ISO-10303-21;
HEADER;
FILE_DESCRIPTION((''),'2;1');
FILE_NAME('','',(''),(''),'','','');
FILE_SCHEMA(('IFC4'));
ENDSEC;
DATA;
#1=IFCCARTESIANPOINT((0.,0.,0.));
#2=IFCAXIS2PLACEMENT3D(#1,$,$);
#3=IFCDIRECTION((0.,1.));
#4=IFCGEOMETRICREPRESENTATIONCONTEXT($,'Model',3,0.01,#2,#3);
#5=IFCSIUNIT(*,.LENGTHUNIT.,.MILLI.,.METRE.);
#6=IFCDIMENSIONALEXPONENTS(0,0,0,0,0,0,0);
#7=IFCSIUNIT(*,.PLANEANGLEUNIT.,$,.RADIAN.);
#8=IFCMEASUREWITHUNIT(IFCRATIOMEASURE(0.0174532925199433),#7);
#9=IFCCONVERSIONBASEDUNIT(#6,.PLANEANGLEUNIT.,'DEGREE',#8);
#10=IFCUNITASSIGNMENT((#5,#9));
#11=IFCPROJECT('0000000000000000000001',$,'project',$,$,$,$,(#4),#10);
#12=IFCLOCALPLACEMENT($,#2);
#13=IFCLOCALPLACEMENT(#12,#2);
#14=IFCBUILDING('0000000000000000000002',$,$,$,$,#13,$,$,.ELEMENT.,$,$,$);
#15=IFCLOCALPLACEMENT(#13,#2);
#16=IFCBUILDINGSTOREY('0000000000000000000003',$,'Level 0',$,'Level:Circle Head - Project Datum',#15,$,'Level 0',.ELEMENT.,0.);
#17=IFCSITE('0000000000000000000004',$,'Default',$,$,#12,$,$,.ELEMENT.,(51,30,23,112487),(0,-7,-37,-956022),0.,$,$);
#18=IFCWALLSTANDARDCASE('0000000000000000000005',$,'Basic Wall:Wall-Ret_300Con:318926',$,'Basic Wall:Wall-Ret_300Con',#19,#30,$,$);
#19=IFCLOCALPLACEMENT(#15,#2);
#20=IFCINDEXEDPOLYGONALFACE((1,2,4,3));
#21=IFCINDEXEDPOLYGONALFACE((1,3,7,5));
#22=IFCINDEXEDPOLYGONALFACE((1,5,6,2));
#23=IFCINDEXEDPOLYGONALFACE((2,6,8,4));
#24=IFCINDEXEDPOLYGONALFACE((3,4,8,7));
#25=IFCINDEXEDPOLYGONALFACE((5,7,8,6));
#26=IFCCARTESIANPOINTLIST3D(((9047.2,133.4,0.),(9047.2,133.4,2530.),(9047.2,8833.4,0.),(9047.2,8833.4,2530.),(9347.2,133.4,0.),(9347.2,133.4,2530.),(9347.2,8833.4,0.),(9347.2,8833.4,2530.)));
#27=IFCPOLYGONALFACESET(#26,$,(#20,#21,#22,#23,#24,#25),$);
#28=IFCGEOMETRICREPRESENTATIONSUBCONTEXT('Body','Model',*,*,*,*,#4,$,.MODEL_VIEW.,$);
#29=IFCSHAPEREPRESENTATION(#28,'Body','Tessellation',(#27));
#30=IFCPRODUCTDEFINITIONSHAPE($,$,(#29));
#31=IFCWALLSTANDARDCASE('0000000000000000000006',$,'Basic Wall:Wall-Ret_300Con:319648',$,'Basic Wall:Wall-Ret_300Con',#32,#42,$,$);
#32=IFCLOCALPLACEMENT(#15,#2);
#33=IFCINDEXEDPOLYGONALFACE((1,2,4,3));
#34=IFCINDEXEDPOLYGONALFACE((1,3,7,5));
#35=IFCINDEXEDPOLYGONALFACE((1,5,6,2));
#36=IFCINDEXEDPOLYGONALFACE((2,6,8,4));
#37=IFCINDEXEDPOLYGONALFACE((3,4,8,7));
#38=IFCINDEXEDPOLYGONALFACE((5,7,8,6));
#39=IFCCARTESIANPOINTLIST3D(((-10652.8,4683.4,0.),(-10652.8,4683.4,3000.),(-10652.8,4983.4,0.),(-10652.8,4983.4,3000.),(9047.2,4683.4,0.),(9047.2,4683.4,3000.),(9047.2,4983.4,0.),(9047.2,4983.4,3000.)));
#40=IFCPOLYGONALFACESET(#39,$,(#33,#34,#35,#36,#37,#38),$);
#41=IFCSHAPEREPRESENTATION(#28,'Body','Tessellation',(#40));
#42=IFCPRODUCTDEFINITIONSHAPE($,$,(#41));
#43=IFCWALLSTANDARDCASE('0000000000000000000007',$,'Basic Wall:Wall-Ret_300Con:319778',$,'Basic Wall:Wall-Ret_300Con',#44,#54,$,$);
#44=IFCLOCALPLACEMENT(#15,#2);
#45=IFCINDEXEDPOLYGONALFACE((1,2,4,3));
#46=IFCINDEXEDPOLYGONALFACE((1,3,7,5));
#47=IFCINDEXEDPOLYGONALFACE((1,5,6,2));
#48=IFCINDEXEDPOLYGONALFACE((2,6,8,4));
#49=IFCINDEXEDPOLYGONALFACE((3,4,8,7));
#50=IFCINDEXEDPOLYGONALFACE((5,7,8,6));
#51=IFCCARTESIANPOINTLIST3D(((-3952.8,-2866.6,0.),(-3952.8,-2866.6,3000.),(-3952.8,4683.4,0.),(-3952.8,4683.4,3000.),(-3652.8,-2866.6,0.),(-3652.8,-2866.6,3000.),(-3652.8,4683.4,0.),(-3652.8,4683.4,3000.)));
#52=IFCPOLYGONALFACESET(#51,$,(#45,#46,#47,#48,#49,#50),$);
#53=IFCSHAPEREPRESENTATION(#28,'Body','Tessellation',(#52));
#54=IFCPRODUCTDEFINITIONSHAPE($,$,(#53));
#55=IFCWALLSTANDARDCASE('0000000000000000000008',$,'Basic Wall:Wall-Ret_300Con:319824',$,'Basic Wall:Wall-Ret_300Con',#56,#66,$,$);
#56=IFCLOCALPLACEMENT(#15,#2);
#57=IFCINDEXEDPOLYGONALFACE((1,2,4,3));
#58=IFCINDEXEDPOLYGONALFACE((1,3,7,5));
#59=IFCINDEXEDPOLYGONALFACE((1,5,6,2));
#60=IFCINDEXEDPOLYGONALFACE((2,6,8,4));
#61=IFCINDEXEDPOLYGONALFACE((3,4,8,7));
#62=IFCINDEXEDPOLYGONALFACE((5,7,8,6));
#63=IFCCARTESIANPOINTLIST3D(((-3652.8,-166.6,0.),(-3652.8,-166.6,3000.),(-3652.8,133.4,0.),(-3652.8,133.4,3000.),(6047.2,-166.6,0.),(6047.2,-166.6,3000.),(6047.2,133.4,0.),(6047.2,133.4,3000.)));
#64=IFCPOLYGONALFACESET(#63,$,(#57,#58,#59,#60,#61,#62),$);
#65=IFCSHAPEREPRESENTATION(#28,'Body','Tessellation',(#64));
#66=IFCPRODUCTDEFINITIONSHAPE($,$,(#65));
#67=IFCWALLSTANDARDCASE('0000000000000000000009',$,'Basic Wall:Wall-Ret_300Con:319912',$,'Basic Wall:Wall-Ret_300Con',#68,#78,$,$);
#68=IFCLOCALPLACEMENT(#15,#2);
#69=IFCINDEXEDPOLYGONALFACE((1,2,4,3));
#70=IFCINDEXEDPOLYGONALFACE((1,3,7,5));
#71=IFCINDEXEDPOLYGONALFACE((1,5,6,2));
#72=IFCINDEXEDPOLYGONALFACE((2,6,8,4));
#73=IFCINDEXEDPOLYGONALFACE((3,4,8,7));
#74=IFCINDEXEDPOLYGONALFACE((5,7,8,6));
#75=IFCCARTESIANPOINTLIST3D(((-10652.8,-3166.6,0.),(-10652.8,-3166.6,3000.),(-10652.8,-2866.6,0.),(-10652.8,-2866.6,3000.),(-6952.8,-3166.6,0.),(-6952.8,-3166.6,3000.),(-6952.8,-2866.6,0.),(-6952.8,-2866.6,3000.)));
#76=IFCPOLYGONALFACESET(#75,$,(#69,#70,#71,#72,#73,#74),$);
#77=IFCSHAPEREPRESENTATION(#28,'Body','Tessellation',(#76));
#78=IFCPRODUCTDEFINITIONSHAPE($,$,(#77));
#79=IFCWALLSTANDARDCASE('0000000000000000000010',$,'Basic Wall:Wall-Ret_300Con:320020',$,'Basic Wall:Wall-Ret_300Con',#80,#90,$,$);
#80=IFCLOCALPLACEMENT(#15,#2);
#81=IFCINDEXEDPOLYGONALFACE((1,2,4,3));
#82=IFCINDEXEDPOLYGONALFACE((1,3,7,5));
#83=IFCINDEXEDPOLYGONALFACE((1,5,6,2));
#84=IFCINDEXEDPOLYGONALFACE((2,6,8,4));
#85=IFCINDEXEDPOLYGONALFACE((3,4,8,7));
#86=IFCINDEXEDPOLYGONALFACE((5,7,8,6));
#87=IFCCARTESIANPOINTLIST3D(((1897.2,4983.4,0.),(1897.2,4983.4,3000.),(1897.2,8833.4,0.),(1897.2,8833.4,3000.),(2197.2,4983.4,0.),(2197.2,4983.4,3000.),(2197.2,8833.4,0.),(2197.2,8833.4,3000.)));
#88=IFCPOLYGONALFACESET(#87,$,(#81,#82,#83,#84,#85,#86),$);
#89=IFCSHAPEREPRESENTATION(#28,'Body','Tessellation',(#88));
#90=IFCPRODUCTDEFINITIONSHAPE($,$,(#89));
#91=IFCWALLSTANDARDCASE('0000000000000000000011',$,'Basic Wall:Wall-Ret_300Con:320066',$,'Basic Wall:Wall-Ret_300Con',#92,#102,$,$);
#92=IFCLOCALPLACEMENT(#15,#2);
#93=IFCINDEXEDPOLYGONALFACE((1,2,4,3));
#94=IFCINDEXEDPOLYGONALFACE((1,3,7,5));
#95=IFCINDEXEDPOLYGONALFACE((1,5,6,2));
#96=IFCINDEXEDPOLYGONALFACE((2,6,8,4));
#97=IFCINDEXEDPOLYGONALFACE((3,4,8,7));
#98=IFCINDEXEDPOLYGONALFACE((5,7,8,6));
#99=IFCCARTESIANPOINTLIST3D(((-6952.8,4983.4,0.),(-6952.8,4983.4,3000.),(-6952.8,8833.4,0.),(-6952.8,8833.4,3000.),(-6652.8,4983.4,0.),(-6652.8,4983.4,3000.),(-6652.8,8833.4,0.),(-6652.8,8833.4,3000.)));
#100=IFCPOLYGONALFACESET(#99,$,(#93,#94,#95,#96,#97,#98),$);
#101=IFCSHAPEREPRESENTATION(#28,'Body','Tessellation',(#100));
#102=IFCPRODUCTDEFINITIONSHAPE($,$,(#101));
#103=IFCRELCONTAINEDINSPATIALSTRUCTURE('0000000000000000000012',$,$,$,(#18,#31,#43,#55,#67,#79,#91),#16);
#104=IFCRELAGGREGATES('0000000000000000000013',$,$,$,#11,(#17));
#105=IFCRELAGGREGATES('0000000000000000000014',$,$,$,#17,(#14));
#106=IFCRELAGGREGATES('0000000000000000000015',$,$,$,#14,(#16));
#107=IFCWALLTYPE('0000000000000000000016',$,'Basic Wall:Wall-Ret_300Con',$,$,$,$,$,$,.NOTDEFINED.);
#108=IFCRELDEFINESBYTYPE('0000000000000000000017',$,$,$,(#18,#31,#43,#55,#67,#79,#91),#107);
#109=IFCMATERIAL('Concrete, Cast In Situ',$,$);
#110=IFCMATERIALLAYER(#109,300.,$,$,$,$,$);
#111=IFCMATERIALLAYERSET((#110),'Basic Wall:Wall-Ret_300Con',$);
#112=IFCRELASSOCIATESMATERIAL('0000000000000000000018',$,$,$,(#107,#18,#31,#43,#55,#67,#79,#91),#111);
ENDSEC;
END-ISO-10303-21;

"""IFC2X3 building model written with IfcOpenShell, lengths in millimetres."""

from ifc_helpers import new_model, entity, si_unit, converted_unit, direction, frame, frame_2d, origin, place, context, subcontext, project, spatial, polyline, rectangle, extrude, clip, bounded_halfspace, material, layer, layer_set, layer_usage, type_object, element, save


model = new_model("IFC2X3")

# Units and contexts
model_context = context("Model", 3, precision=0.01, world=origin(), true_north=direction((0.0, 1.0)))
body_context = subcontext(model_context, "Body", "Model", "MODEL_VIEW")
ifc_project = project(units=[si_unit("LENGTHUNIT", "METRE", prefix="MILLI"), converted_unit("PLANEANGLEUNIT", "DEGREE", entity("IfcRatioMeasure", 0.0174532925199433), si_unit("PLANEANGLEUNIT", "RADIAN"), dimensions=[0, 0, 0, 0, 0, 0, 0])], contexts=[model_context])

# Site, building, storey
site_placement = place(None, origin())
site = spatial("IfcSite", under=ifc_project, at=site_placement, Name="Default", CompositionType="ELEMENT", RefLatitude=(51, 30, 23, 112487), RefLongitude=(0, -7, -37, -956022), RefElevation=0.0)
building_placement = place(site_placement, origin())
building = spatial("IfcBuilding", under=site, at=building_placement, CompositionType="ELEMENT")
storey_placement = place(building_placement, origin())
storey = spatial("IfcBuildingStorey", under=building, at=storey_placement, Name="Level 0", ObjectType="Level:Circle Head - Project Datum", LongName="Level 0", CompositionType="ELEMENT", Elevation=0.0)

# Walls
ifc_material_1 = material(Name="Concrete, Cast In Situ")
ifc_layer_1 = layer(ifc_material_1, 300.0)
ifc_layer_set_1 = layer_set([ifc_layer_1], Name="Basic Wall:Wall-Ret_300Con")
wall_type = type_object("IfcWallType", Name="Basic Wall:Wall-Ret_300Con", PredefinedType="NOTDEFINED", material=ifc_layer_set_1)
ifc_layer_usage_1 = layer_usage(ifc_layer_set_1, "AXIS2", "NEGATIVE", 150.0)
wall_1_placement = place(storey_placement, frame((9197.2, 8833.4, 0.0), z_axis=(0.0, 0.0, 1.0), x_axis=(0.0, -1.0, 0.0)))
element("IfcWallStandardCase", 1, at=wall_1_placement, inside=storey, type_object=wall_type, material=ifc_layer_usage_1, Name="Basic Wall:Wall-Ret_300Con:318926", ObjectType="Basic Wall:Wall-Ret_300Con", context=body_context, shape_type="Clipping", body=[
    clip(extrude(rectangle(XDim=8700.0, YDim=300.0, at=frame_2d((4350.0, 0.0), x_axis=(-1.0, 0.0))), origin(), (0.0, 0.0, 1.0), 2530.0), bounded_halfspace(frame((0.0, -150.0, 2530.0), z_axis=(0.0, 0.0, -1.0), x_axis=(0.0, 1.0, 0.0)), True, frame((0.0, -150.0, 2530.0)), polyline([(0.0, 0.0), (8700.0, 0.0), (8700.0, 300.0), (0.0, 300.0), (0.0, 0.0)]))),
])
ifc_layer_usage_2 = layer_usage(ifc_layer_set_1, "AXIS2", "NEGATIVE", 150.0)
wall_2_placement = place(storey_placement, frame((-10652.8, 4833.4, 0.0)))
element("IfcWallStandardCase", 2, at=wall_2_placement, inside=storey, type_object=wall_type, material=ifc_layer_usage_2, Name="Basic Wall:Wall-Ret_300Con:319648", ObjectType="Basic Wall:Wall-Ret_300Con", context=body_context, shape_type="SweptSolid", body=[
    extrude(rectangle(XDim=19700.0, YDim=300.0, at=frame_2d((9850.0, 0.0), x_axis=(-1.0, 0.0))), origin(), (0.0, 0.0, 1.0), 3000.0),
])
ifc_layer_usage_3 = layer_usage(ifc_layer_set_1, "AXIS2", "NEGATIVE", 150.0)
wall_3_placement = place(storey_placement, frame((-3802.8, 4683.4, 0.0), z_axis=(0.0, 0.0, 1.0), x_axis=(0.0, -1.0, 0.0)))
element("IfcWallStandardCase", 3, at=wall_3_placement, inside=storey, type_object=wall_type, material=ifc_layer_usage_3, Name="Basic Wall:Wall-Ret_300Con:319778", ObjectType="Basic Wall:Wall-Ret_300Con", context=body_context, shape_type="SweptSolid", body=[
    extrude(rectangle(XDim=7550.0, YDim=300.0, at=frame_2d((3775.0, 0.0), x_axis=(-1.0, 0.0))), origin(), (0.0, 0.0, 1.0), 3000.0),
])
ifc_layer_usage_4 = layer_usage(ifc_layer_set_1, "AXIS2", "NEGATIVE", 150.0)
wall_4_placement = place(storey_placement, frame((6047.2, -16.6, 0.0), z_axis=(0.0, 0.0, 1.0), x_axis=(-1.0, 0.0, 0.0)))
element("IfcWallStandardCase", 4, at=wall_4_placement, inside=storey, type_object=wall_type, material=ifc_layer_usage_4, Name="Basic Wall:Wall-Ret_300Con:319824", ObjectType="Basic Wall:Wall-Ret_300Con", context=body_context, shape_type="SweptSolid", body=[
    extrude(rectangle(XDim=9700.0, YDim=300.0, at=frame_2d((4850.0, 0.0), x_axis=(-1.0, 0.0))), origin(), (0.0, 0.0, 1.0), 3000.0),
])
ifc_layer_usage_5 = layer_usage(ifc_layer_set_1, "AXIS2", "NEGATIVE", 150.0)
wall_5_placement = place(storey_placement, frame((-6952.8, -3016.6, 0.0), z_axis=(0.0, 0.0, 1.0), x_axis=(-1.0, 0.0, 0.0)))
element("IfcWallStandardCase", 5, at=wall_5_placement, inside=storey, type_object=wall_type, material=ifc_layer_usage_5, Name="Basic Wall:Wall-Ret_300Con:319912", ObjectType="Basic Wall:Wall-Ret_300Con", context=body_context, shape_type="SweptSolid", body=[
    extrude(rectangle(XDim=3700.0, YDim=300.0, at=frame_2d((1850.0, 0.0), x_axis=(-1.0, 0.0))), origin(), (0.0, 0.0, 1.0), 3000.0),
])
ifc_layer_usage_6 = layer_usage(ifc_layer_set_1, "AXIS2", "NEGATIVE", 150.0)
wall_6_placement = place(storey_placement, frame((2047.2, 4983.4, 0.0), z_axis=(0.0, 0.0, 1.0), x_axis=(0.0, 1.0, 0.0)))
element("IfcWallStandardCase", 6, at=wall_6_placement, inside=storey, type_object=wall_type, material=ifc_layer_usage_6, Name="Basic Wall:Wall-Ret_300Con:320020", ObjectType="Basic Wall:Wall-Ret_300Con", context=body_context, shape_type="SweptSolid", body=[
    extrude(rectangle(XDim=3850.0, YDim=300.0, at=frame_2d((1925.0, 0.0), x_axis=(-1.0, 0.0))), origin(), (0.0, 0.0, 1.0), 3000.0),
])
ifc_layer_usage_7 = layer_usage(ifc_layer_set_1, "AXIS2", "NEGATIVE", 150.0)
wall_7_placement = place(storey_placement, frame((-6802.8, 4983.4, 0.0), z_axis=(0.0, 0.0, 1.0), x_axis=(0.0, 1.0, 0.0)))
element("IfcWallStandardCase", 7, at=wall_7_placement, inside=storey, type_object=wall_type, material=ifc_layer_usage_7, Name="Basic Wall:Wall-Ret_300Con:320066", ObjectType="Basic Wall:Wall-Ret_300Con", context=body_context, shape_type="SweptSolid", body=[
    extrude(rectangle(XDim=3850.0, YDim=300.0, at=frame_2d((1925.0, 0.0), x_axis=(-1.0, 0.0))), origin(), (0.0, 0.0, 1.0), 3000.0),
])

save(model, "model.ifc")
